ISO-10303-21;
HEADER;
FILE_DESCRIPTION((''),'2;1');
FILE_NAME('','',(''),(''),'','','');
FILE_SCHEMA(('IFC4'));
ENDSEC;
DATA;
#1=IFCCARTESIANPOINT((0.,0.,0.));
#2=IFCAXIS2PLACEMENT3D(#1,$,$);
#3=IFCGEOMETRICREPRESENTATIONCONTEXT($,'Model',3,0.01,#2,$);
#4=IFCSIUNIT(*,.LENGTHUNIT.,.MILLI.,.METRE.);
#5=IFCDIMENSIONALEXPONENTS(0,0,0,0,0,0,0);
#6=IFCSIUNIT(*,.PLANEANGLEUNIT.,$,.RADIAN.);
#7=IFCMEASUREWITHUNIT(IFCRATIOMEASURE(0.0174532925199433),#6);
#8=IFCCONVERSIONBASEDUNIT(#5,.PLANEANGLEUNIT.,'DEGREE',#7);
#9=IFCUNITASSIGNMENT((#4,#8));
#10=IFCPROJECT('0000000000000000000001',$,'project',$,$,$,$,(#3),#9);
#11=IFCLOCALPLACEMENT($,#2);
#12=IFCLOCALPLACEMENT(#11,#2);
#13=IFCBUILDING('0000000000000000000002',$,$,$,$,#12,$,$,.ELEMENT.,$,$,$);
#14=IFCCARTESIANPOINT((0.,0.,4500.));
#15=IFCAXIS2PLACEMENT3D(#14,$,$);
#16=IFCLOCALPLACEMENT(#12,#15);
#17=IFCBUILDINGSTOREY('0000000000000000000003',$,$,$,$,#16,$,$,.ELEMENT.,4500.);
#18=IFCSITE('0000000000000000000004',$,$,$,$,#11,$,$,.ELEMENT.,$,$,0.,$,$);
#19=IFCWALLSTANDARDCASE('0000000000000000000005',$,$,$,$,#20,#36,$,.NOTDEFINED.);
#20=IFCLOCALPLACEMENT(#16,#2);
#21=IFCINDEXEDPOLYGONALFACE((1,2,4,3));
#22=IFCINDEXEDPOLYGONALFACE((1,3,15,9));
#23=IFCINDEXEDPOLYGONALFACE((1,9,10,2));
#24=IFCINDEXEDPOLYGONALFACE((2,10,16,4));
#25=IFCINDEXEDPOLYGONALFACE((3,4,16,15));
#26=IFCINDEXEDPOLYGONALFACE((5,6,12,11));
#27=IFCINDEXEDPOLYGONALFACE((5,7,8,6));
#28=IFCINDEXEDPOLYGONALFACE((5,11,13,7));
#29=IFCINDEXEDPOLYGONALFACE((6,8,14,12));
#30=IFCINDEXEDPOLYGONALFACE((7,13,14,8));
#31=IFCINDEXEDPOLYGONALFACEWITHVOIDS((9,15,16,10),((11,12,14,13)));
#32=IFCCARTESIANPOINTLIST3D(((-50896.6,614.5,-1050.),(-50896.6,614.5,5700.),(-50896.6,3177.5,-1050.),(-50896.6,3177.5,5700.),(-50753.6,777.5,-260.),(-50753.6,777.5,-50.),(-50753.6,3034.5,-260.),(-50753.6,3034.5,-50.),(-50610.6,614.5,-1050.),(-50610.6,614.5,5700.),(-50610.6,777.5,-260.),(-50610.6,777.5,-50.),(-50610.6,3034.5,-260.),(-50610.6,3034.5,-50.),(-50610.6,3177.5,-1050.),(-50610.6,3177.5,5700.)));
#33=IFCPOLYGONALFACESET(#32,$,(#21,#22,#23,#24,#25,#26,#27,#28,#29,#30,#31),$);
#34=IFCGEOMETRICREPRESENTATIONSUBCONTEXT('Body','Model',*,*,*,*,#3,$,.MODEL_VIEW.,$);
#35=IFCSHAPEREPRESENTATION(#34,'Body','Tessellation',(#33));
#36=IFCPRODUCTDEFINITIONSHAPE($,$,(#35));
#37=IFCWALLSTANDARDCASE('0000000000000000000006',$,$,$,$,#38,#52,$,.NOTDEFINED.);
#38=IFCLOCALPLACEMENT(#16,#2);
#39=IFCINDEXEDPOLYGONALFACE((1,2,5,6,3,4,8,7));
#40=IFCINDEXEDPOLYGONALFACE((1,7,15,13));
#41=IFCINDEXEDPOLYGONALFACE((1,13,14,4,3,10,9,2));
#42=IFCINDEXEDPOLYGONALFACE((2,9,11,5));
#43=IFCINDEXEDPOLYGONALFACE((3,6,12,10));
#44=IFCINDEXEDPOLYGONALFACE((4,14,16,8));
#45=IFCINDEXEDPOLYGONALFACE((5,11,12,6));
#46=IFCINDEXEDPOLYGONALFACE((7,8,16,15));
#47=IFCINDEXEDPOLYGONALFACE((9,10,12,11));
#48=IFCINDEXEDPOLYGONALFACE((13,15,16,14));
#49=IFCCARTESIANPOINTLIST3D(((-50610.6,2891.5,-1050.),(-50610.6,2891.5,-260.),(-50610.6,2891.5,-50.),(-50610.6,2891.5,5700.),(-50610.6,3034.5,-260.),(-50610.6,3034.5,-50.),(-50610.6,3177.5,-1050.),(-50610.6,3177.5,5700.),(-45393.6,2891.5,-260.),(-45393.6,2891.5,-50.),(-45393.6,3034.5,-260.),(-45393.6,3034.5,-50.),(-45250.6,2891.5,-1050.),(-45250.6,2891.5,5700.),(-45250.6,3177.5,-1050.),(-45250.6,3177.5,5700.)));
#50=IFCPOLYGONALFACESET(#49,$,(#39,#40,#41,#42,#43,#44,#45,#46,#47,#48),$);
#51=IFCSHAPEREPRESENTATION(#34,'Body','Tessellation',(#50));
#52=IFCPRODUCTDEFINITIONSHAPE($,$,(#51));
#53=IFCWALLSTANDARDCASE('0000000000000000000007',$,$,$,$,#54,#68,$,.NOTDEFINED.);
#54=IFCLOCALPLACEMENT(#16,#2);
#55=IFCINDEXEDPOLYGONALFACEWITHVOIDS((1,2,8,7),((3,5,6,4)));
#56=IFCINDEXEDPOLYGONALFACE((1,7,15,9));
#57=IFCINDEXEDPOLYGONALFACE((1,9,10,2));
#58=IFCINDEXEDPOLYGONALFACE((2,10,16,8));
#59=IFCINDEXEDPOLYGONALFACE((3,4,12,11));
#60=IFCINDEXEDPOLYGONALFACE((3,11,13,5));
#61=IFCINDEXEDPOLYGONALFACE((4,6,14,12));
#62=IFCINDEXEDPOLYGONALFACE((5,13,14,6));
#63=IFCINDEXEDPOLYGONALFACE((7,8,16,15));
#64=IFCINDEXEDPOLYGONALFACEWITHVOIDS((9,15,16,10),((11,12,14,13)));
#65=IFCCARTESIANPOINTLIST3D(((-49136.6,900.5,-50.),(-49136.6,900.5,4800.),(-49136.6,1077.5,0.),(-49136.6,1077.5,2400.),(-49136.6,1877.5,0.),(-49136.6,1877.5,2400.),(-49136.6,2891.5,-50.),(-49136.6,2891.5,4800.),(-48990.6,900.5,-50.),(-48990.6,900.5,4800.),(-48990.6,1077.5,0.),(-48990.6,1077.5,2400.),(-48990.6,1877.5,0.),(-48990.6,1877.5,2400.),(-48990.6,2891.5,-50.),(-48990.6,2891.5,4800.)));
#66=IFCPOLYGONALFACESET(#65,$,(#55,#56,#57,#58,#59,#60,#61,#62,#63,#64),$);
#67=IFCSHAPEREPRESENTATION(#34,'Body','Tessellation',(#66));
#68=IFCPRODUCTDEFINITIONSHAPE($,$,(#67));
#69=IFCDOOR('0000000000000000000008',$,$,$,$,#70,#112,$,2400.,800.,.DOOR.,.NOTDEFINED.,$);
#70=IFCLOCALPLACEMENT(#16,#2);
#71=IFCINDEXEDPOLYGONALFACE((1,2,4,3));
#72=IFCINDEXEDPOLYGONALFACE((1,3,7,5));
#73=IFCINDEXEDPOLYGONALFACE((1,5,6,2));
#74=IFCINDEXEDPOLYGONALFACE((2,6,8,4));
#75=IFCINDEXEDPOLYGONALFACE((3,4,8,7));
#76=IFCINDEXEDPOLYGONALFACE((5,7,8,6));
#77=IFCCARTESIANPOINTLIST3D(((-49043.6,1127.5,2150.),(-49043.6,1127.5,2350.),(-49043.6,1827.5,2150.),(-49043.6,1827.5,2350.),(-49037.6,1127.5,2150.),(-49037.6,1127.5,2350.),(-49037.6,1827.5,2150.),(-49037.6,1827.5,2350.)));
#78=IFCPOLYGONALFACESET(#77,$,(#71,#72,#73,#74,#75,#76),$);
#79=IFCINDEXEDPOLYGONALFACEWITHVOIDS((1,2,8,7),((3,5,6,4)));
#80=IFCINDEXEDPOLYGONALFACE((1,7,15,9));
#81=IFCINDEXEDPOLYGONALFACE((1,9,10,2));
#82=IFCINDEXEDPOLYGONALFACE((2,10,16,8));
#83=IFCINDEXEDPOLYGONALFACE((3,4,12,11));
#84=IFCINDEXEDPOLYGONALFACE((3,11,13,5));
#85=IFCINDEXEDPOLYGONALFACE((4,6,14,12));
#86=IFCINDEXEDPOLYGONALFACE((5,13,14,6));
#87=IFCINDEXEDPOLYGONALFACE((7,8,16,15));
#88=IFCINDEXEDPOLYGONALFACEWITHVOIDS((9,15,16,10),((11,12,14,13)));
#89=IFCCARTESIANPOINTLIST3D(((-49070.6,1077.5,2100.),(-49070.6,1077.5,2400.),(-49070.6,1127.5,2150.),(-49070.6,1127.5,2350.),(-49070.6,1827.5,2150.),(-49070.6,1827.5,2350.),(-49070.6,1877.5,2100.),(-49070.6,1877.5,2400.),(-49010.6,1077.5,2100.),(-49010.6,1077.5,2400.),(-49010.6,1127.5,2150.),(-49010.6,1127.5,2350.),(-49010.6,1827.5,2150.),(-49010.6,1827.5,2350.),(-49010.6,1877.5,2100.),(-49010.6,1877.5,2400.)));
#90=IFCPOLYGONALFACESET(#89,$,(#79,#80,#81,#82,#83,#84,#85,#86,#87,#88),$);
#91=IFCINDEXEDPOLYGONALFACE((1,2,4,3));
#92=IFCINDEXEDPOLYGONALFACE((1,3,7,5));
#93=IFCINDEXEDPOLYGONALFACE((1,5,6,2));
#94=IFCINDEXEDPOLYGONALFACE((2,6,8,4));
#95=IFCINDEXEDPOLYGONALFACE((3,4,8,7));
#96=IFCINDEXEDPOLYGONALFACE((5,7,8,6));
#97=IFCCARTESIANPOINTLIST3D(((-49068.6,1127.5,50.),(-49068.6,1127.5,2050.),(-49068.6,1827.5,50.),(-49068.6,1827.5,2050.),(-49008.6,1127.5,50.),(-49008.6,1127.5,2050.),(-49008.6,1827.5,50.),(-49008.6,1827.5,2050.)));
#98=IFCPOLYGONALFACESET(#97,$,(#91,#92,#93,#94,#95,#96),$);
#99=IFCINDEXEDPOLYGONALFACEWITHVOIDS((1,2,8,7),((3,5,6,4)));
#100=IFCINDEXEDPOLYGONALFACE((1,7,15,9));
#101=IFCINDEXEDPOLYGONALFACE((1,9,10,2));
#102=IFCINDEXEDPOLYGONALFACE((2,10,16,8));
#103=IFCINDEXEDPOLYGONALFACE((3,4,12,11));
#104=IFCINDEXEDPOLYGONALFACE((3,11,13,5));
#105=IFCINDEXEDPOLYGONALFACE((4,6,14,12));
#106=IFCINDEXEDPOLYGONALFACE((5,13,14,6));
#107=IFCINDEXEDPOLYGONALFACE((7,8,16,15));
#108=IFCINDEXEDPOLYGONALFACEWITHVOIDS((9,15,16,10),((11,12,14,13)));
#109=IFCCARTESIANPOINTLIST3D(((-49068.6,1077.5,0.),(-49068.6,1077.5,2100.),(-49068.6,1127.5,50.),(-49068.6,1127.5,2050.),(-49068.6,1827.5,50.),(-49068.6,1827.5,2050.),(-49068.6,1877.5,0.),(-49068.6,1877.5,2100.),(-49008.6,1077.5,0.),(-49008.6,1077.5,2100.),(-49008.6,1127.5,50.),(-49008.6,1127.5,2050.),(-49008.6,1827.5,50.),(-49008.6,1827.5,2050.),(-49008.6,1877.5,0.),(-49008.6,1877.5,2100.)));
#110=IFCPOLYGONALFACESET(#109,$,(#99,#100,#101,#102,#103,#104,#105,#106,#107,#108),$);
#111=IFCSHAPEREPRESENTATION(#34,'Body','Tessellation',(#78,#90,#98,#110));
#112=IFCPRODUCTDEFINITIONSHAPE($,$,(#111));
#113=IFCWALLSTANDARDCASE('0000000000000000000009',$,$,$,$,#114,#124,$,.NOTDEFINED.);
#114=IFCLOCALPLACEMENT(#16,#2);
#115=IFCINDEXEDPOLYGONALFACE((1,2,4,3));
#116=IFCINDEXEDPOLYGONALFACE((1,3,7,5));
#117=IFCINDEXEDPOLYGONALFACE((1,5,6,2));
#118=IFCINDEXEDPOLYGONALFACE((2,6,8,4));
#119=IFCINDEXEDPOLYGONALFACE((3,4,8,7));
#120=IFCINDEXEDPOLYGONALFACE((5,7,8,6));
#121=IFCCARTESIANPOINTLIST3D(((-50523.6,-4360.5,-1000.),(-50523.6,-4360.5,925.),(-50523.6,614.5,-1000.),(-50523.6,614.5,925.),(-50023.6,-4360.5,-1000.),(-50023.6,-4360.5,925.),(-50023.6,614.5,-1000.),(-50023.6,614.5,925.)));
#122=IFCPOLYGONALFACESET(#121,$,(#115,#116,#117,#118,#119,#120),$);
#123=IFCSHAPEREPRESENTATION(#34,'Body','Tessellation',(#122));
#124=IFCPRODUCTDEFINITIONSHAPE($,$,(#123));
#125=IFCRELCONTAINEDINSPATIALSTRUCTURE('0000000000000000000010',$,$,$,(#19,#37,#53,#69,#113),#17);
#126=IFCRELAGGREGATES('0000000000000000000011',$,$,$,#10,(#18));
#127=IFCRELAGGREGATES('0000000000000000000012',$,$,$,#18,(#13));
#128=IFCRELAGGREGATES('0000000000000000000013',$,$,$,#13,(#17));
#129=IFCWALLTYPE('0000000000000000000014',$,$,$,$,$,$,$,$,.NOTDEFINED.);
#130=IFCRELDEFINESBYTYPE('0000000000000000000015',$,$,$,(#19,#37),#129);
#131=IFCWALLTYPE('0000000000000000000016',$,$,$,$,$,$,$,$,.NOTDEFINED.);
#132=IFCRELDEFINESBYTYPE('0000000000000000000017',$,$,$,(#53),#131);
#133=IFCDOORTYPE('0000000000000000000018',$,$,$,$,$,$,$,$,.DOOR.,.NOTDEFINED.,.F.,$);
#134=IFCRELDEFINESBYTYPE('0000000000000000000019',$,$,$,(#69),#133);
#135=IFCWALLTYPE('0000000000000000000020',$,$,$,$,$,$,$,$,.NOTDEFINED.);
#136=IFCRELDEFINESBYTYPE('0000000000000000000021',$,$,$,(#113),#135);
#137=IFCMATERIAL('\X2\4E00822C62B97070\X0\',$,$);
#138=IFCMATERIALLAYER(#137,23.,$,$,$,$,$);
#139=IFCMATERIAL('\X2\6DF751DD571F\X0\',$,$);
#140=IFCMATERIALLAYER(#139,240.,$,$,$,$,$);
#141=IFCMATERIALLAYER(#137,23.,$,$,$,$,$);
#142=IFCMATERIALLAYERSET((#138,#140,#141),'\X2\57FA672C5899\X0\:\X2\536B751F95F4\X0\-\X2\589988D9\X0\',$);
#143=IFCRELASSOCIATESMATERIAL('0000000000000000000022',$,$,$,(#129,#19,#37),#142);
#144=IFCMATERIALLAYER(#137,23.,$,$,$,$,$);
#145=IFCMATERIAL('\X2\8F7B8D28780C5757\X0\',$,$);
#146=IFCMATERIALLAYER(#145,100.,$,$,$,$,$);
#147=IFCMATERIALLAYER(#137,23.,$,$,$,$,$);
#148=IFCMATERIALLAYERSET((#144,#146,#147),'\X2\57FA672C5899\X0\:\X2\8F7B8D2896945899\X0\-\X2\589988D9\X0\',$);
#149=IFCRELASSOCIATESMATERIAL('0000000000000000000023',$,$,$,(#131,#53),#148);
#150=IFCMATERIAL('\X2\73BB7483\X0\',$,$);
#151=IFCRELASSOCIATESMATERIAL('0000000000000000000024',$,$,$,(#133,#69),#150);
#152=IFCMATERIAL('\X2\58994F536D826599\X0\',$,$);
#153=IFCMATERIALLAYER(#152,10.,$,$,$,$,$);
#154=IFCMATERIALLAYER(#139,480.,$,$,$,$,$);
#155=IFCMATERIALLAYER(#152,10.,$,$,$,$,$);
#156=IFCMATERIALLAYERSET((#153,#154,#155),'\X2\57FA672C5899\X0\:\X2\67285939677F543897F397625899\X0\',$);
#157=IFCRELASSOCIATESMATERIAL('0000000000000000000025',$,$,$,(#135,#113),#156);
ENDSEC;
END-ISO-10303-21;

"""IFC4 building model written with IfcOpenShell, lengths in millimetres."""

from ifc_helpers import new_model, entity, si_unit, converted_unit, frame, frame_2d, origin, place, context, subcontext, project, spatial, polyline, rectangle, outline, extrude, source, transform, mapped, material, layer, layer_set, layer_usage, type_object, type_shapes, element, fill, save


model = new_model("IFC4")

# Units and contexts
model_context = context("Model", 3, precision=0.01, world=origin())
body_context = subcontext(model_context, "Body", "Model", "MODEL_VIEW")
ifc_project = project(units=[si_unit("LENGTHUNIT", "METRE", prefix="MILLI"), converted_unit("PLANEANGLEUNIT", "DEGREE", entity("IfcRatioMeasure", 0.0174532925199433), si_unit("PLANEANGLEUNIT", "RADIAN"), dimensions=[0, 0, 0, 0, 0, 0, 0])], contexts=[model_context])

# Site, building, storey
site_placement = place(None, origin())
site = spatial("IfcSite", under=ifc_project, at=site_placement, CompositionType="ELEMENT", RefElevation=0.0)
building_placement = place(site_placement, origin())
building = spatial("IfcBuilding", under=site, at=building_placement, CompositionType="ELEMENT")
storey_placement = place(building_placement, frame((0.0, 0.0, 4500.0)))
storey = spatial("IfcBuildingStorey", under=building, at=storey_placement, CompositionType="ELEMENT", Elevation=4500.0)

# Walls, openings
ifc_material_1 = material(Name="一般抹灰")
ifc_layer_1 = layer(ifc_material_1, 23.0)
ifc_material_2 = material(Name="混凝土")
ifc_layer_2 = layer(ifc_material_2, 240.0)
ifc_layer_3 = layer(ifc_material_1, 23.0)
ifc_layer_set_1 = layer_set([ifc_layer_1, ifc_layer_2, ifc_layer_3], Name="基本墙:卫生间-墙裙")
ifc_layer_usage_1 = layer_usage(ifc_layer_set_1, "AXIS2", "NEGATIVE", 143.0)
wall_type_1 = type_object("IfcWallType", PredefinedType="NOTDEFINED", material=ifc_layer_set_1)
wall_1_placement = place(storey_placement, frame((-50753.6, 614.5, -1050.0), z_axis=(0.0, 0.0, 1.0), x_axis=(0.0, 1.0, 0.0)))
wall_1 = element("IfcWallStandardCase", 1, at=wall_1_placement, inside=storey, type_object=wall_type_1, material=ifc_layer_usage_1, PredefinedType="NOTDEFINED", context=body_context, shape_type="SweptSolid", body=[
    extrude(rectangle(XDim=2563.0, YDim=286.0, at=frame_2d((1281.5, 0.0), x_axis=(-1.0, 0.0))), origin(), (0.0, 0.0, 1.0), 6750.0),
])
opening_1_placement = place(storey_placement, frame((-50753.6, 614.5, -1050.0), z_axis=(0.0, 0.0, 1.0), x_axis=(0.0, 1.0, 0.0)))
element("IfcOpeningElement", 2, at=opening_1_placement, cuts=wall_1, PredefinedType="OPENING", context=body_context, shape_type="SweptSolid", body=[
    extrude(rectangle(XDim=2257.0, YDim=143.0, at=frame_2d((-3.3, -23.8), x_axis=(1.0, 0.0))), frame((1288.2, -95.3, 790.0), z_axis=(0.0, 0.0, 1.0), x_axis=(-1.0, 0.0, 0.0)), (0.0, 0.0, 1.0), 210.0),
])
ifc_layer_usage_2 = layer_usage(ifc_layer_set_1, "AXIS2", "NEGATIVE", 143.0)
wall_2_placement = place(storey_placement, frame((-50610.6, 3034.5, -1050.0)))
wall_2 = element("IfcWallStandardCase", 3, at=wall_2_placement, inside=storey, type_object=wall_type_1, material=ifc_layer_usage_2, PredefinedType="NOTDEFINED", context=body_context, shape_type="SweptSolid", body=[
    extrude(rectangle(XDim=5360.0, YDim=286.0, at=frame_2d((2680.0, 0.0), x_axis=(-1.0, 0.0))), origin(), (0.0, 0.0, 1.0), 6750.0),
])
opening_2_placement = place(storey_placement, frame((-50610.6, 3034.5, -1050.0)))
element("IfcOpeningElement", 4, at=opening_2_placement, cuts=wall_2, PredefinedType="OPENING", context=body_context, shape_type="SweptSolid", body=[
    extrude(rectangle(XDim=5217.0, YDim=143.0, at=frame_2d((493.1, -14.3), x_axis=(1.0, 0.0))), frame((3101.6, -85.8, 790.0), z_axis=(0.0, 0.0, 1.0), x_axis=(-1.0, 0.0, 0.0)), (0.0, 0.0, 1.0), 210.0),
])

# Wall, opening, door
ifc_layer_4 = layer(ifc_material_1, 23.0)
ifc_material_3 = material(Name="轻质砌块")
ifc_layer_5 = layer(ifc_material_3, 100.0)
ifc_layer_6 = layer(ifc_material_1, 23.0)
ifc_layer_set_2 = layer_set([ifc_layer_4, ifc_layer_5, ifc_layer_6], Name="基本墙:轻质隔墙-墙裙")
ifc_layer_usage_3 = layer_usage(ifc_layer_set_2, "AXIS2", "POSITIVE", -73.0)
wall_type_2 = type_object("IfcWallType", PredefinedType="NOTDEFINED", material=ifc_layer_set_2)
wall_3_placement = place(storey_placement, frame((-49063.6, 900.5, -50.0), z_axis=(0.0, 0.0, 1.0), x_axis=(0.0, 1.0, 0.0)))
wall_3 = element("IfcWallStandardCase", 5, at=wall_3_placement, inside=storey, type_object=wall_type_2, material=ifc_layer_usage_3, PredefinedType="NOTDEFINED", context=body_context, shape_type="SweptSolid", body=[
    extrude(rectangle(XDim=1991.0, YDim=146.0, at=frame_2d((995.5, 0.0), x_axis=(-1.0, 0.0))), origin(), (0.0, 0.0, 1.0), 4850.0),
])
opening_3_placement = place(wall_3_placement, frame((177.0, -73.0, 50.0)))
opening_3 = element("IfcOpeningElement", 6, at=opening_3_placement, cuts=wall_3, PredefinedType="OPENING", context=body_context, shape_type="SweptSolid", body=[
    extrude(rectangle(XDim=2400.0, YDim=800.0, at=frame_2d((1200.0, 400.0), x_axis=(1.0, 0.0))), frame((0.0, 0.0, 0.0), z_axis=(0.0, 1.0, 0.0), x_axis=(0.0, 0.0, 1.0)), (0.0, 0.0, 1.0), 146.0),
])
ifc_material_4 = material(Name="玻璃")
door_type = type_object("IfcDoorType", OperationType="NOTDEFINED", ParameterTakesPrecedence=False, PredefinedType="DOOR", material=ifc_material_4)
shared_shape_1 = source(origin(), body_context, "Body", "SweptSolid", [
    extrude(rectangle(XDim=6.0, YDim=700.0, at=frame_2d((0.0, 0.0), x_axis=(1.0, 0.0))), frame((400.0, 50.0, 2150.0), z_axis=(0.0, 0.0, 1.0), x_axis=(0.0, -1.0, 0.0)), (0.0, 0.0, 1.0), 200.0),
    extrude(outline(polyline([(-400.0, -150.0), (400.0, -150.0), (400.0, 150.0), (-400.0, 150.0), (-400.0, -150.0)]), holes=[polyline([(-350.0, -100.0), (-350.0, 100.0), (350.0, 100.0), (350.0, -100.0), (-350.0, -100.0)])]), frame((400.0, 20.0, 2250.0), z_axis=(0.0, 1.0, 0.0), x_axis=(1.0, 0.0, 0.0)), (0.0, 0.0, 1.0), 60.0),
    extrude(rectangle(XDim=700.0, YDim=60.0, at=frame_2d((0.0, 0.0), x_axis=(1.0, 0.0))), frame((400.0, 48.0, 50.0), z_axis=(0.0, 0.0, 1.0), x_axis=(-1.0, 0.0, 0.0)), (0.0, 0.0, 1.0), 2000.0),
    extrude(outline(polyline([(-1050.0, -400.0), (1050.0, -400.0), (1050.0, 400.0), (-1050.0, 400.0), (-1050.0, -400.0)]), holes=[polyline([(-1000.0, 350.0), (1000.0, 350.0), (1000.0, -350.0), (-1000.0, -350.0), (-1000.0, 350.0)])]), frame((400.0, 18.0, 1050.0), z_axis=(0.0, 1.0, 0.0), x_axis=(0.0, 0.0, -1.0)), (0.0, 0.0, 1.0), 60.0),
])
type_shapes(door_type, [shared_shape_1])
door_placement = place(opening_3_placement, origin())
door = element("IfcDoor", 7, at=door_placement, inside=storey, type_object=door_type, material=ifc_material_4, OperationType="NOTDEFINED", OverallHeight=2400.0, OverallWidth=800.0, PredefinedType="DOOR", context=body_context, shape_type="MappedRepresentation", body=[
    mapped(shared_shape_1, transform((0.0, 0.0, 0.0), scale=1.0)),
])
fill(opening_3, door)

# Wall
ifc_material_5 = material(Name="墙体涂料")
ifc_layer_7 = layer(ifc_material_5, 10.0)
ifc_layer_8 = layer(ifc_material_2, 480.0)
ifc_layer_9 = layer(ifc_material_5, 10.0)
ifc_layer_set_3 = layer_set([ifc_layer_7, ifc_layer_8, ifc_layer_9], Name="基本墙:木夹板吸音面墙")
ifc_layer_usage_4 = layer_usage(ifc_layer_set_3, "AXIS2", "POSITIVE", -250.0)
wall_type_3 = type_object("IfcWallType", PredefinedType="NOTDEFINED", material=ifc_layer_set_3)
wall_4_placement = place(storey_placement, frame((-50273.6, 614.5, -1000.0), z_axis=(0.0, 0.0, 1.0), x_axis=(0.0, -1.0, 0.0)))
element("IfcWallStandardCase", 8, at=wall_4_placement, inside=storey, type_object=wall_type_3, material=ifc_layer_usage_4, PredefinedType="NOTDEFINED", context=body_context, shape_type="SweptSolid", body=[
    extrude(rectangle(XDim=4975.0, YDim=500.0, at=frame_2d((2487.5, 0.0), x_axis=(-1.0, 0.0))), origin(), (0.0, 0.0, 1.0), 1925.0),
])

save(model, "model.ifc")
